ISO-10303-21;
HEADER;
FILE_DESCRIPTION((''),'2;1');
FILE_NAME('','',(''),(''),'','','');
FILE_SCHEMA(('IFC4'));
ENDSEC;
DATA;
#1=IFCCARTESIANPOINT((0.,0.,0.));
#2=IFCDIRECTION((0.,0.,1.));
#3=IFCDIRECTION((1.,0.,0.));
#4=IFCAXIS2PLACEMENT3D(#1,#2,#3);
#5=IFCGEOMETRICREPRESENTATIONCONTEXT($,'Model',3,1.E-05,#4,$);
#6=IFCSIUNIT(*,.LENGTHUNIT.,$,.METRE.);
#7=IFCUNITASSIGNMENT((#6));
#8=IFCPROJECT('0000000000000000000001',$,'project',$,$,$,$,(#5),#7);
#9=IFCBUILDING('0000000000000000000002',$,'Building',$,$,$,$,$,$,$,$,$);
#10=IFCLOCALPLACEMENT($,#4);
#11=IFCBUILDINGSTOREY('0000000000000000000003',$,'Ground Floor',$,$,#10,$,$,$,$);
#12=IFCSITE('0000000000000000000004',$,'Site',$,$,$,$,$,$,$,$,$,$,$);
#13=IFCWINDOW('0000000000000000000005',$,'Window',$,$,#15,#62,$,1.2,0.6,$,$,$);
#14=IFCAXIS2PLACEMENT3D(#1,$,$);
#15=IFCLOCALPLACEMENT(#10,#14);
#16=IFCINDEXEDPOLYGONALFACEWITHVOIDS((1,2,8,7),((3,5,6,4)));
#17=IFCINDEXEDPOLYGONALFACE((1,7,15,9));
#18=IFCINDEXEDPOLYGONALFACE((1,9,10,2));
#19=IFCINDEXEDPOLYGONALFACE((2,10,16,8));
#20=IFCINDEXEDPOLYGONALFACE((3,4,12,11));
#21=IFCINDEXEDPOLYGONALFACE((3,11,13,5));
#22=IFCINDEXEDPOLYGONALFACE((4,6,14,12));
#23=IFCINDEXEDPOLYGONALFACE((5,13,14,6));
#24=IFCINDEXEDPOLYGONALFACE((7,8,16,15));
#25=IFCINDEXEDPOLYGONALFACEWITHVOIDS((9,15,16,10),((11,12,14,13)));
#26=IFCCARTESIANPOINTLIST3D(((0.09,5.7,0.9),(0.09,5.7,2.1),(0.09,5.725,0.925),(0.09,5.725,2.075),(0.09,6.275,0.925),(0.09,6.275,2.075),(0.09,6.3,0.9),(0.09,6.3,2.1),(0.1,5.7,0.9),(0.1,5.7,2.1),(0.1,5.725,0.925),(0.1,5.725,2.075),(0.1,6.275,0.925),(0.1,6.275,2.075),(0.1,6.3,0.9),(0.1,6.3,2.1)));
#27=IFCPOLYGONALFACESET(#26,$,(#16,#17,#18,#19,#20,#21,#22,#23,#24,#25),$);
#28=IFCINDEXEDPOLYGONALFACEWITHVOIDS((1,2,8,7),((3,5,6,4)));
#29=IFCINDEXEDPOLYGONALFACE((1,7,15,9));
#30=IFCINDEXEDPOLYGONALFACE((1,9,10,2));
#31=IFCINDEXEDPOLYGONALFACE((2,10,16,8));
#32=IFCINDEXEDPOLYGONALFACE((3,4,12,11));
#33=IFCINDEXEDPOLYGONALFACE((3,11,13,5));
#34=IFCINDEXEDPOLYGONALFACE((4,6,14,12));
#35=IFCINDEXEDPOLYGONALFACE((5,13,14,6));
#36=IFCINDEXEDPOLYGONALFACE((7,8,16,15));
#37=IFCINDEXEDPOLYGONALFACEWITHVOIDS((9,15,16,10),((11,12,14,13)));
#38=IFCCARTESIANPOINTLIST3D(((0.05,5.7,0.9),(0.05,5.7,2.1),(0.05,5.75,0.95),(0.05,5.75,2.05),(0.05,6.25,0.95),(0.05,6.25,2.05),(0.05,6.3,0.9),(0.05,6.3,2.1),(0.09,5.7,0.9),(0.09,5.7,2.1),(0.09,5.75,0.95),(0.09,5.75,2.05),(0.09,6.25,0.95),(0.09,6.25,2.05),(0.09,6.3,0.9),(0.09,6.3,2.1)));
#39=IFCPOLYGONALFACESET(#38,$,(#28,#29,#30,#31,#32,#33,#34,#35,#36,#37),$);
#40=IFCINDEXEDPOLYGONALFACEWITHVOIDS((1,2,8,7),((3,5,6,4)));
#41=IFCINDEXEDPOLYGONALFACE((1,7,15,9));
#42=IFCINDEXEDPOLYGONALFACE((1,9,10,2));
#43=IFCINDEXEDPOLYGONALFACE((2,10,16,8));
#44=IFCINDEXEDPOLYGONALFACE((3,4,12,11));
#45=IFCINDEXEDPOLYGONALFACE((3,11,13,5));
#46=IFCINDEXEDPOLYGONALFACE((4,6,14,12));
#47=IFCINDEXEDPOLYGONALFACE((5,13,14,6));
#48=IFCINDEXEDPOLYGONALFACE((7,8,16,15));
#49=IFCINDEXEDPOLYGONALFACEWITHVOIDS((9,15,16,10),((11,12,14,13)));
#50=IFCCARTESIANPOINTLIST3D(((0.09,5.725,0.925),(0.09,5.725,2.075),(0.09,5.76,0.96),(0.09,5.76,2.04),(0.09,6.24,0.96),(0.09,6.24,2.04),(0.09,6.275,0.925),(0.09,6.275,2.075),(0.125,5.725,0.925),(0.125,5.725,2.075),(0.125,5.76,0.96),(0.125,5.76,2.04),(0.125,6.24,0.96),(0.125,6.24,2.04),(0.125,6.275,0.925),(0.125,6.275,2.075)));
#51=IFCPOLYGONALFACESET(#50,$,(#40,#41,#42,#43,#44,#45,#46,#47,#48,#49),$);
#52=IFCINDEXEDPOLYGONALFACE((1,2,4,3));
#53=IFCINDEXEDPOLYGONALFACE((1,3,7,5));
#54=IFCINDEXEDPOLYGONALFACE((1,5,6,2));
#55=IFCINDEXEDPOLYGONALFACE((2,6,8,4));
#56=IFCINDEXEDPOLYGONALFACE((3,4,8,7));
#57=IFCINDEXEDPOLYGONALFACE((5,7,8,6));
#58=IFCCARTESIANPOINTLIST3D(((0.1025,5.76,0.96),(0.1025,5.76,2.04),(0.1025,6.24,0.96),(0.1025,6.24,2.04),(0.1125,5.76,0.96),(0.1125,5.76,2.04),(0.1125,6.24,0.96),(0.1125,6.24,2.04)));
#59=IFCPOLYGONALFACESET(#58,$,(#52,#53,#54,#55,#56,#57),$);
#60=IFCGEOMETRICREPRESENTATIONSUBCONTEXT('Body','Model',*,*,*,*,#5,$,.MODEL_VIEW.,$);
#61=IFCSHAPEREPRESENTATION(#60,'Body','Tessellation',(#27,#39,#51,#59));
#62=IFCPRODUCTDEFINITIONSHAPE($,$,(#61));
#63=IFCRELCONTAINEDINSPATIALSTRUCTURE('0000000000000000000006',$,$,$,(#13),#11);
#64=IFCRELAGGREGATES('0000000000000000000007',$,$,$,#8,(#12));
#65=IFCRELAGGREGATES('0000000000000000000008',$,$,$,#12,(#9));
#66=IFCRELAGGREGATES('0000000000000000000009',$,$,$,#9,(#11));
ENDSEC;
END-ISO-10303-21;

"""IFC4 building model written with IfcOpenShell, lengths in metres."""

from ifc_helpers import new_model, si_unit, frame, origin_with_axes, place, context, subcontext, project, spatial, line, indexed_curve, outline, extrude, element, save


model = new_model("IFC4")

# Units and contexts
model_context = context("Model", 3, precision=1e-05, world=origin_with_axes())
body_context = subcontext(model_context, "Body", "Model", "MODEL_VIEW")
ifc_project = project(units=[si_unit("LENGTHUNIT", "METRE")], contexts=[model_context])

# Site, building, storey
site = spatial("IfcSite", under=ifc_project, Name="Site")
building = spatial("IfcBuilding", under=site, Name="Building")
storey_placement = place(None, origin_with_axes())
storey = spatial("IfcBuildingStorey", under=building, at=storey_placement, Name="Ground Floor")

# Window
window_1_placement = place(storey_placement, frame((0.0, 6.3, 0.9), z_axis=(0.0, 0.0, 1.0), x_axis=(0.0, -1.0, 0.0)))
element("IfcWindow", 1, at=window_1_placement, inside=storey, Name="Window", OverallHeight=1.2, OverallWidth=0.6, context=body_context, shape_type="SweptSolid", body=[
    extrude(outline(indexed_curve([(0.0, 0.0), (0.6, 0.0), (0.6, 1.2), (0.0, 1.2)], segments=[line(1, 2, 3, 4, 1)]), holes=[indexed_curve([(0.025, 0.025), (0.575, 0.025), (0.575, 1.175), (0.025, 1.175)], segments=[line(1, 2, 3, 4, 1)])]), frame((0.0, 0.09, 0.0), z_axis=(0.0, -1.0, 0.0), x_axis=(1.0, 0.0, 0.0)), (0.0, 0.0, -1.0), 0.01),
    extrude(outline(indexed_curve([(0.0, 0.0), (0.6, 0.0), (0.6, 1.2), (0.0, 1.2)], segments=[line(1, 2, 3, 4, 1)]), holes=[indexed_curve([(0.05, 0.05), (0.55, 0.05), (0.55, 1.15), (0.05, 1.15)], segments=[line(1, 2, 3, 4, 1)])]), frame((0.0, 0.05, 0.0), z_axis=(0.0, -1.0, 0.0), x_axis=(1.0, 0.0, 0.0)), (0.0, 0.0, -1.0), 0.04),
    extrude(outline(indexed_curve([(0.0, 0.0), (0.55, 0.0), (0.55, 1.15), (0.0, 1.15)], segments=[line(1, 2, 3, 4, 1)]), holes=[indexed_curve([(0.035, 0.035), (0.515, 0.035), (0.515, 1.115), (0.035, 1.115)], segments=[line(1, 2, 3, 4, 1)])]), frame((0.025, 0.09, 0.025), z_axis=(0.0, -1.0, 0.0), x_axis=(1.0, 0.0, 0.0)), (0.0, 0.0, -1.0), 0.035),
    extrude(outline(indexed_curve([(0.035, 0.035), (0.515, 0.035), (0.515, 1.115), (0.035, 1.115)], segments=[line(1, 2, 3, 4, 1)])), frame((0.025, 0.1025, 0.025), z_axis=(0.0, -1.0, 0.0), x_axis=(1.0, 0.0, 0.0)), (0.0, 0.0, -1.0), 0.01),
])

save(model, "model.ifc")
